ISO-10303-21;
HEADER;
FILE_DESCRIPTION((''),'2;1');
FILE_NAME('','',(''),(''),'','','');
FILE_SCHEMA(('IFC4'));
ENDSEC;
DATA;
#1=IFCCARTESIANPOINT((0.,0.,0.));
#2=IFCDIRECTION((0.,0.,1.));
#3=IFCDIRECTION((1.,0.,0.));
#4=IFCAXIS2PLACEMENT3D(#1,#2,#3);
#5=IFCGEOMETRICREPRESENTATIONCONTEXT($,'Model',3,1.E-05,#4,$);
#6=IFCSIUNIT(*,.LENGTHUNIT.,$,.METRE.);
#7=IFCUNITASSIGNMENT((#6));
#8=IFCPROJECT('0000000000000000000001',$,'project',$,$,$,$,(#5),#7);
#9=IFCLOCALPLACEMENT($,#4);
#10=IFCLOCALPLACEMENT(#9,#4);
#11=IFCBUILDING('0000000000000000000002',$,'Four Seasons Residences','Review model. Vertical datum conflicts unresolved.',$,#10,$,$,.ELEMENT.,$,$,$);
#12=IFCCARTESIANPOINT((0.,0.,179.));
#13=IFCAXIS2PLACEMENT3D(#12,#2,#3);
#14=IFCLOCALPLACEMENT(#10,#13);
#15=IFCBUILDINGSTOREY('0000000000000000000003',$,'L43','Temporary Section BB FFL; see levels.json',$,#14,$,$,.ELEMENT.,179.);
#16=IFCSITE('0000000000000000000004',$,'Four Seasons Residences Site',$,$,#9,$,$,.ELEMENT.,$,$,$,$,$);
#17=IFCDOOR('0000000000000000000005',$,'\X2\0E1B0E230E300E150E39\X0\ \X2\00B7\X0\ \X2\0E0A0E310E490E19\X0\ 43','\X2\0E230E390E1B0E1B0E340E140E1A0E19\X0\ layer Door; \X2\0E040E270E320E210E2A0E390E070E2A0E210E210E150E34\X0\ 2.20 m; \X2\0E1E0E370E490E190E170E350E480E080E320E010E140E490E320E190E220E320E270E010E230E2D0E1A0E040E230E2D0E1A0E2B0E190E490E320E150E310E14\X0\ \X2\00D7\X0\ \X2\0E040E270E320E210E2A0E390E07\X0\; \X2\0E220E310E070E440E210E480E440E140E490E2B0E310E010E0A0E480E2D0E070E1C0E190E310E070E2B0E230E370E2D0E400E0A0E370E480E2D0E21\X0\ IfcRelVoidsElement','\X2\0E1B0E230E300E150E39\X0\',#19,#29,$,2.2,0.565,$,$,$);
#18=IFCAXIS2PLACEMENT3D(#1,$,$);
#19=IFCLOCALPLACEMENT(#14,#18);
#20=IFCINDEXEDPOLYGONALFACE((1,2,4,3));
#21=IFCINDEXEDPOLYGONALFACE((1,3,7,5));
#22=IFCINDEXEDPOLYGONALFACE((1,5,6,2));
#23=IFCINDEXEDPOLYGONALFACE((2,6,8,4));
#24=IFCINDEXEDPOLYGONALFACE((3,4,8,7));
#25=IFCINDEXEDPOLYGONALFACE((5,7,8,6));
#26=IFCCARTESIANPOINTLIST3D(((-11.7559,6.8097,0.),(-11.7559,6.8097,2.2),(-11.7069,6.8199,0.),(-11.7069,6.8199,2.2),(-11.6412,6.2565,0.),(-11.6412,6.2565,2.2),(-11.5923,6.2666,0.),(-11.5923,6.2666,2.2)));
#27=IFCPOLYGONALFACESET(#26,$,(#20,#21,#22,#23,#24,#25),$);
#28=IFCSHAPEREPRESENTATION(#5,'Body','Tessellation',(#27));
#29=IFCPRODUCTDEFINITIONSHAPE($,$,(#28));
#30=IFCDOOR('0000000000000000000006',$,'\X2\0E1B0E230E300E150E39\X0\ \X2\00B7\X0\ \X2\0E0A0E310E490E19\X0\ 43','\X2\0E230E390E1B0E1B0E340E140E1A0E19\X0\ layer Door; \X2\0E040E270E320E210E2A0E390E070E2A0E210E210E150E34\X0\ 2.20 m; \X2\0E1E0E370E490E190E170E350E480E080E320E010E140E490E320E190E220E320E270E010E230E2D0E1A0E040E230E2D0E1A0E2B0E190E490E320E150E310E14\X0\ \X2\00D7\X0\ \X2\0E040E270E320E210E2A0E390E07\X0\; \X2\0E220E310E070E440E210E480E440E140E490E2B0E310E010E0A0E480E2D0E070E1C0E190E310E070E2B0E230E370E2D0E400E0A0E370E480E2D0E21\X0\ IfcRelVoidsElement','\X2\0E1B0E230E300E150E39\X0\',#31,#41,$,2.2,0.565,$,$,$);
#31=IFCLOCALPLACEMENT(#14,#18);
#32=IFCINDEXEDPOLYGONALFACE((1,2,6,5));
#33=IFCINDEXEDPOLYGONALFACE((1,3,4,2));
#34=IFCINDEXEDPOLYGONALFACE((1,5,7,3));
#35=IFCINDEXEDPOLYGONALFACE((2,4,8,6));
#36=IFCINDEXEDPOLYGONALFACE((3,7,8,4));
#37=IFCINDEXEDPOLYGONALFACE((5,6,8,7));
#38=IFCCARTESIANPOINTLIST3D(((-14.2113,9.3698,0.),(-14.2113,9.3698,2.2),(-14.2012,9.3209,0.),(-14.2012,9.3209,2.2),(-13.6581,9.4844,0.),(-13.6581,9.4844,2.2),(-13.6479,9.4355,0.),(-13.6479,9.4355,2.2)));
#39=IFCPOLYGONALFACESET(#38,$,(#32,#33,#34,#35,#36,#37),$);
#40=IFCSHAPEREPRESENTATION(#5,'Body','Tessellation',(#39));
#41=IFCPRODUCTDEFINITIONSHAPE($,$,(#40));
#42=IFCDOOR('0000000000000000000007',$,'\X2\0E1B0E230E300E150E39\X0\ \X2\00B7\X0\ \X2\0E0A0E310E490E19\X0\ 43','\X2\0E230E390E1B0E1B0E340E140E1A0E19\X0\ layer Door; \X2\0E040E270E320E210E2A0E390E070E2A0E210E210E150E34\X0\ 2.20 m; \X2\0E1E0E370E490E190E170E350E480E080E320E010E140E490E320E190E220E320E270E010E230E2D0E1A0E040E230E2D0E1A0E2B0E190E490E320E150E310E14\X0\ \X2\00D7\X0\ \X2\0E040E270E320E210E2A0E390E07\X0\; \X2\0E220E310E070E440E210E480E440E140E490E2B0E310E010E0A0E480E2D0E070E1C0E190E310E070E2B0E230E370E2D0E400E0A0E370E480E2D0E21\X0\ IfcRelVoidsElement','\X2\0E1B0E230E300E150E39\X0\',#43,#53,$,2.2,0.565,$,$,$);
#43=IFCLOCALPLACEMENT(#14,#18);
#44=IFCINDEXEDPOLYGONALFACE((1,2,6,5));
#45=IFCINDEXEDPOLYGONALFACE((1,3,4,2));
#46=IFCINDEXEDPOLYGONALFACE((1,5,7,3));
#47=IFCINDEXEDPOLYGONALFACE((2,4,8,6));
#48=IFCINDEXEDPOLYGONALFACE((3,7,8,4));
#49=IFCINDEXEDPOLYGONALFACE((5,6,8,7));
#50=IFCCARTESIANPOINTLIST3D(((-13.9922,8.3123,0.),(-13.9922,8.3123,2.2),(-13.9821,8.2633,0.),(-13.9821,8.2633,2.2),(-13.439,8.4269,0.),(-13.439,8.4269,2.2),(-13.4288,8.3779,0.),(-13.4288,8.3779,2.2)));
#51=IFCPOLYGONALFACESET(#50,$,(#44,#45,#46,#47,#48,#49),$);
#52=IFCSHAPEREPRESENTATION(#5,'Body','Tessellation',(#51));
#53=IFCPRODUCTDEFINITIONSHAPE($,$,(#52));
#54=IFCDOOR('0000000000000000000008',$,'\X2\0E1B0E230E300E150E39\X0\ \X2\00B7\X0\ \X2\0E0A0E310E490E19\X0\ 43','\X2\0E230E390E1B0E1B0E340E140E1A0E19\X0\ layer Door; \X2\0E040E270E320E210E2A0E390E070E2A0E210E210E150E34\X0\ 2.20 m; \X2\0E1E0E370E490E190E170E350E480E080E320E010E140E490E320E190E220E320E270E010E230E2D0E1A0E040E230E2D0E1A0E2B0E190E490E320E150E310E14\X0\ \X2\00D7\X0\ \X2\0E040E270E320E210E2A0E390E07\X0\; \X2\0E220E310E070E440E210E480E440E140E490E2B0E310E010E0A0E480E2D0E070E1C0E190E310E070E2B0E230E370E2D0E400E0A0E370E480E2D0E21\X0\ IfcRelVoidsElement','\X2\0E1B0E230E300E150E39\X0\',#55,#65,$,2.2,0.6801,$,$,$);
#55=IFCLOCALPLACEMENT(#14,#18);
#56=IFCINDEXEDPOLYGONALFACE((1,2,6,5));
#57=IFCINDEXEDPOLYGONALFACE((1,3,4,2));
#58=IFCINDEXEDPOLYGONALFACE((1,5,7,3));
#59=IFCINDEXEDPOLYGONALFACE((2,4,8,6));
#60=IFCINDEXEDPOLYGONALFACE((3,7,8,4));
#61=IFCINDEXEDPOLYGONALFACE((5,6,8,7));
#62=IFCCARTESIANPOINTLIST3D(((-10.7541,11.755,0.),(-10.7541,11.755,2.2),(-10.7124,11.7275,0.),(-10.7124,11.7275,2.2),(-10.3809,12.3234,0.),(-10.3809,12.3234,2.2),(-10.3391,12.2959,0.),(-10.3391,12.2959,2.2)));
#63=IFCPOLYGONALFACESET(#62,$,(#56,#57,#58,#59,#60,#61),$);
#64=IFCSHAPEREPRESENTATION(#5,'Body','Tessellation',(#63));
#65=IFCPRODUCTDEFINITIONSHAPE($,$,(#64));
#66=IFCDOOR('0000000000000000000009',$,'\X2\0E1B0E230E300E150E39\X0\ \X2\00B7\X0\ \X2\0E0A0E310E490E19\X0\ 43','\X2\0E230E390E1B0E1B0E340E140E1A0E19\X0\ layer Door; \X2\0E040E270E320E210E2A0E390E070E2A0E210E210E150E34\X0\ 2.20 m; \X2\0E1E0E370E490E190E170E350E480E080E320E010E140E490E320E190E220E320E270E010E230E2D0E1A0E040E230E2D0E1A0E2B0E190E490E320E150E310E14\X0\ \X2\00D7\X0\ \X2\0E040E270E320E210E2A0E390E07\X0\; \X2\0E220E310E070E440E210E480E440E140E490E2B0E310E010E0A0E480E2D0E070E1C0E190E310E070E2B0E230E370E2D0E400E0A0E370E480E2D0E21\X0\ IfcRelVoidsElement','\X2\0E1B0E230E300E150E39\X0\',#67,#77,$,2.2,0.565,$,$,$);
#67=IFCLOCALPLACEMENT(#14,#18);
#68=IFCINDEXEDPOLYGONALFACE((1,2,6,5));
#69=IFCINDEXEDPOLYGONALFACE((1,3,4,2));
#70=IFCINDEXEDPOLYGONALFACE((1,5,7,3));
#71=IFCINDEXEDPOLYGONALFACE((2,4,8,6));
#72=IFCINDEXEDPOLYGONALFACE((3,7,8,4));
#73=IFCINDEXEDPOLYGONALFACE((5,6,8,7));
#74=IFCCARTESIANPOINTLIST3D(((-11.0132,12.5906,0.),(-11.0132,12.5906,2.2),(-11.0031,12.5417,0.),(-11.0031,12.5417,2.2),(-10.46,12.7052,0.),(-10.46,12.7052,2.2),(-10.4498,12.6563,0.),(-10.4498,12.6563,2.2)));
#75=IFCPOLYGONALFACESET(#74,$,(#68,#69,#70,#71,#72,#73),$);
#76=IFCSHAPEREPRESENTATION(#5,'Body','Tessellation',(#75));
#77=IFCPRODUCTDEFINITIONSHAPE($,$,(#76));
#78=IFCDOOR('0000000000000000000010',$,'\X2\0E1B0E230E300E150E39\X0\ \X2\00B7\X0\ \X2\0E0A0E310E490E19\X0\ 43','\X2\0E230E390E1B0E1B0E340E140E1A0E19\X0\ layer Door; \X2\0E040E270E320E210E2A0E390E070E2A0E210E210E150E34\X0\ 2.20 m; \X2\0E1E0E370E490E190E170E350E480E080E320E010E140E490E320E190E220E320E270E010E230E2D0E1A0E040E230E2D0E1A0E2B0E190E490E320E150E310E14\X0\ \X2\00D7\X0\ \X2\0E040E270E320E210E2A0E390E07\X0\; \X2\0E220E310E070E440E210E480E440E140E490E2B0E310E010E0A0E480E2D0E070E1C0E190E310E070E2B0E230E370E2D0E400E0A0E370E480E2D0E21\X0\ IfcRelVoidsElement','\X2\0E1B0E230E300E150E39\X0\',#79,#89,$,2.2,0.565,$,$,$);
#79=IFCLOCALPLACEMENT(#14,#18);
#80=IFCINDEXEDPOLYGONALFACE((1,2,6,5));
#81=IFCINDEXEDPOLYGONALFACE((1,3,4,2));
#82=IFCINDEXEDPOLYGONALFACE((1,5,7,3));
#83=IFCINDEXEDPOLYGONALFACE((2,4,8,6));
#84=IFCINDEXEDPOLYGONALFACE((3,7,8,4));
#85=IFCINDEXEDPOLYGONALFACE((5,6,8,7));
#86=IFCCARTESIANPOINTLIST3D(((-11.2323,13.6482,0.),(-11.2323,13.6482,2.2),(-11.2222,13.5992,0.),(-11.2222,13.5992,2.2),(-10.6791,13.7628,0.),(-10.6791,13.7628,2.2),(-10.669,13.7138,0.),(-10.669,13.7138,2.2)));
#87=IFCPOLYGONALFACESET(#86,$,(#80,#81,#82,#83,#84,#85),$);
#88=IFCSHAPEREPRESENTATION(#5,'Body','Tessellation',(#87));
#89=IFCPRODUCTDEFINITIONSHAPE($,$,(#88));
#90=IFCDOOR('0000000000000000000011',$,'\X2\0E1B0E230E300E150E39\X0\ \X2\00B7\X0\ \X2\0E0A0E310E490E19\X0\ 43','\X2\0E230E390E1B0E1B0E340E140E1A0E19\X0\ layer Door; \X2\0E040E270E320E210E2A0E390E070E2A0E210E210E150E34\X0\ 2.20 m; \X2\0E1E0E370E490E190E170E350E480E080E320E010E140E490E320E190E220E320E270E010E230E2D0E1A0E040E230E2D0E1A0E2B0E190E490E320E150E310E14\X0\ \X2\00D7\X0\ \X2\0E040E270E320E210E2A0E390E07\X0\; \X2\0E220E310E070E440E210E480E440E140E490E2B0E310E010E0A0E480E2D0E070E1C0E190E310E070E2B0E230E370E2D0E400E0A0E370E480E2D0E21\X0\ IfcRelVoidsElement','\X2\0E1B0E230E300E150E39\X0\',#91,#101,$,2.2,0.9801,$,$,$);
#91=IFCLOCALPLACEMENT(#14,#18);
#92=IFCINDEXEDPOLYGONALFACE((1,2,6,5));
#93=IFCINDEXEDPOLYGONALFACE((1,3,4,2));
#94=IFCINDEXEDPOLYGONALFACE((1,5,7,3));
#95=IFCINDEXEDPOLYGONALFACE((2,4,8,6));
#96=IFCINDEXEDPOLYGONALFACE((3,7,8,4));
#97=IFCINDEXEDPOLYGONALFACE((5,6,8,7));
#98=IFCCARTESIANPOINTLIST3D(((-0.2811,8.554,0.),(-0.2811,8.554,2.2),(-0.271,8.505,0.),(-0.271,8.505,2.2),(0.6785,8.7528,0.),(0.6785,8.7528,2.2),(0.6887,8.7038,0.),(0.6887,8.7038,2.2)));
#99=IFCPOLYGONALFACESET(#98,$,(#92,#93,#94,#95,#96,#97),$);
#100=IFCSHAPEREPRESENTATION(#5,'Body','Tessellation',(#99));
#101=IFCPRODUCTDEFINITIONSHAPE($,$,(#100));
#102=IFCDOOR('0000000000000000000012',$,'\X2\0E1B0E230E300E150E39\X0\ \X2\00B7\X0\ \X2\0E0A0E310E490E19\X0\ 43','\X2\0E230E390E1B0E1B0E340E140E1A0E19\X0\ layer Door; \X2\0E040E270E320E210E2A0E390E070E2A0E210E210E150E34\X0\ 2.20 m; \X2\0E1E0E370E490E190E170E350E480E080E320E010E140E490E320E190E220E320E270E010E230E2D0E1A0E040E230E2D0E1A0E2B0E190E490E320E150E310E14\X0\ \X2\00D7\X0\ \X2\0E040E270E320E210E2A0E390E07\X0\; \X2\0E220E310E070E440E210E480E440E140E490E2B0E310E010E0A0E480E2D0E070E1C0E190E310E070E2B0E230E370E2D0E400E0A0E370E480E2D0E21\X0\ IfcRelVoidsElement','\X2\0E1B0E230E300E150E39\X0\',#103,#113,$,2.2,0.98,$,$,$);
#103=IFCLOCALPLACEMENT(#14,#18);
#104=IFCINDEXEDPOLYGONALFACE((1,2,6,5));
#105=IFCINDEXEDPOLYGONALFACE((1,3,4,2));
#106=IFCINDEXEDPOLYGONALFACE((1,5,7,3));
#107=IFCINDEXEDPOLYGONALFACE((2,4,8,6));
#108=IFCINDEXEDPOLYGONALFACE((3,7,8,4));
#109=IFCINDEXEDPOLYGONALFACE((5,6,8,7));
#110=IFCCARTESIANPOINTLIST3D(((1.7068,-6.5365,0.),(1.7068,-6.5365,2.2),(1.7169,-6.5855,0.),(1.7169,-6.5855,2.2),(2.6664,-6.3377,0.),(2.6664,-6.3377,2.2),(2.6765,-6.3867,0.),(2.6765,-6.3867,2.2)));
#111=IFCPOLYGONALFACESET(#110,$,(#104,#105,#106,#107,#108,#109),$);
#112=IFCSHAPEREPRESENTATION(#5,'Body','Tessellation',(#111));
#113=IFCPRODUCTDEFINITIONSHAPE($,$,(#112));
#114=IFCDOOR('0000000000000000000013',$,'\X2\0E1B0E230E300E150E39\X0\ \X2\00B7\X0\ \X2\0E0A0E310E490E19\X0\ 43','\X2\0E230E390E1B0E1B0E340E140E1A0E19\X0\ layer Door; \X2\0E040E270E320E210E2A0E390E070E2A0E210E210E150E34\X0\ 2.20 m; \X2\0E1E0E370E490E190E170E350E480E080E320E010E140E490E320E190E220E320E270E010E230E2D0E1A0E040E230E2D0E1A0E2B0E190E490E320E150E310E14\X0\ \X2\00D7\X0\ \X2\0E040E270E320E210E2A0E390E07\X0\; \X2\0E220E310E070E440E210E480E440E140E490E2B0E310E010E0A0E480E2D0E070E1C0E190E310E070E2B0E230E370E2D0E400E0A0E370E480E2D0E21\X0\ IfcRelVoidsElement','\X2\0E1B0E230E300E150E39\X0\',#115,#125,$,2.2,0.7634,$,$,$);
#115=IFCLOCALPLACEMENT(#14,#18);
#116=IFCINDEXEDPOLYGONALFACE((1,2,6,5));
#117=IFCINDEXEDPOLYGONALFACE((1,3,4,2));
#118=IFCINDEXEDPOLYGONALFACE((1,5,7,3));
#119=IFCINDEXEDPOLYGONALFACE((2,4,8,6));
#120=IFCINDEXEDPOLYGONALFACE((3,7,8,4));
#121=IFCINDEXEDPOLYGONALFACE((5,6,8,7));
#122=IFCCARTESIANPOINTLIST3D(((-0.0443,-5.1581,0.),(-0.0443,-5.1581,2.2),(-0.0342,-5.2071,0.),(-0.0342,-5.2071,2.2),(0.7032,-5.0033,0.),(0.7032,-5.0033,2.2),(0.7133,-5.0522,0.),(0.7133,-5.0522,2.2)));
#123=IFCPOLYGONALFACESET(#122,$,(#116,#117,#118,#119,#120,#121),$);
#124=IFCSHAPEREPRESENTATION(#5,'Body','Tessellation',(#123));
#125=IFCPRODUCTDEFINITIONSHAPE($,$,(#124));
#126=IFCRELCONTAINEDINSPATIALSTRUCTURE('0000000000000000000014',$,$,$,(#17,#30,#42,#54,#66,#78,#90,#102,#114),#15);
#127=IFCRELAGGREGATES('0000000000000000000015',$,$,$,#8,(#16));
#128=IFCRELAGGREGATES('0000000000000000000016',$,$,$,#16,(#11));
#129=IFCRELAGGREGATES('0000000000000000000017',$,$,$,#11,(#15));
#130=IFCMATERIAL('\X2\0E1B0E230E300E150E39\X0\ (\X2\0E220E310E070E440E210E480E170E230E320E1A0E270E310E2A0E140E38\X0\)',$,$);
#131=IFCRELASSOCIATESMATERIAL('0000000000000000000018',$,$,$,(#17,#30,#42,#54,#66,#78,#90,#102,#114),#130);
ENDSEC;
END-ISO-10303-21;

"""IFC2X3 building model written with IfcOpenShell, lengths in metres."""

from ifc_helpers import new_model, si_unit, frame, origin_with_axes, place, context, project, spatial, polyline, outline, extrude, material, element, save


model = new_model("IFC2X3")

# Units and contexts
model_context = context("Model", 3, precision=1e-05, world=origin_with_axes())
ifc_project = project(units=[si_unit("LENGTHUNIT", "METRE")], contexts=[model_context])

# Site, building, storey
site_placement = place(None, origin_with_axes())
site = spatial("IfcSite", under=ifc_project, at=site_placement, Name="Four Seasons Residences Site", CompositionType="ELEMENT")
building_placement = place(site_placement, origin_with_axes())
building = spatial("IfcBuilding", under=site, at=building_placement, Name="Four Seasons Residences", Description="Review model. Vertical datum conflicts unresolved.", CompositionType="ELEMENT")
storey_placement = place(building_placement, frame((0.0, 0.0, 179.0), z_axis=(0.0, 0.0, 1.0), x_axis=(1.0, 0.0, 0.0)))
storey = spatial("IfcBuildingStorey", under=building, at=storey_placement, Name="L43", Description="Temporary Section BB FFL; see levels.json", CompositionType="ELEMENT", Elevation=179.0)

# Doors
ifc_material_1 = material(Name="ประตู (ยังไม่ทราบวัสดุ)")
door_1_placement = place(storey_placement, origin_with_axes())
element("IfcDoor", 1, at=door_1_placement, inside=storey, material=ifc_material_1, Name="ประตู · ชั้น 43", Description="รูปปิดบน layer Door; ความสูงสมมติ 2.20 m; พื้นที่จากด้านยาวกรอบครอบหน้าตัด × ความสูง; ยังไม่ได้หักช่องผนังหรือเชื่อม IfcRelVoidsElement", ObjectType="ประตู", OverallHeight=2.2, OverallWidth=0.565, context=model_context, shape_type="SweptSolid", body=[
    extrude(outline(polyline([(-11.5923, 6.2666), (-11.7069, 6.8199), (-11.7559, 6.8097), (-11.6412, 6.2565), (-11.5923, 6.2666)])), origin_with_axes(), (0.0, 0.0, 1.0), 2.2),
])
door_2_placement = place(storey_placement, origin_with_axes())
element("IfcDoor", 2, at=door_2_placement, inside=storey, material=ifc_material_1, Name="ประตู · ชั้น 43", Description="รูปปิดบน layer Door; ความสูงสมมติ 2.20 m; พื้นที่จากด้านยาวกรอบครอบหน้าตัด × ความสูง; ยังไม่ได้หักช่องผนังหรือเชื่อม IfcRelVoidsElement", ObjectType="ประตู", OverallHeight=2.2, OverallWidth=0.565, context=model_context, shape_type="SweptSolid", body=[
    extrude(outline(polyline([(-13.6581, 9.4844), (-14.2113, 9.3698), (-14.2012, 9.3209), (-13.6479, 9.4355), (-13.6581, 9.4844)])), origin_with_axes(), (0.0, 0.0, 1.0), 2.2),
])
door_3_placement = place(storey_placement, origin_with_axes())
element("IfcDoor", 3, at=door_3_placement, inside=storey, material=ifc_material_1, Name="ประตู · ชั้น 43", Description="รูปปิดบน layer Door; ความสูงสมมติ 2.20 m; พื้นที่จากด้านยาวกรอบครอบหน้าตัด × ความสูง; ยังไม่ได้หักช่องผนังหรือเชื่อม IfcRelVoidsElement", ObjectType="ประตู", OverallHeight=2.2, OverallWidth=0.565, context=model_context, shape_type="SweptSolid", body=[
    extrude(outline(polyline([(-13.4288, 8.3779), (-13.9821, 8.2633), (-13.9922, 8.3123), (-13.439, 8.4269), (-13.4288, 8.3779)])), origin_with_axes(), (0.0, 0.0, 1.0), 2.2),
])
door_4_placement = place(storey_placement, origin_with_axes())
element("IfcDoor", 4, at=door_4_placement, inside=storey, material=ifc_material_1, Name="ประตู · ชั้น 43", Description="รูปปิดบน layer Door; ความสูงสมมติ 2.20 m; พื้นที่จากด้านยาวกรอบครอบหน้าตัด × ความสูง; ยังไม่ได้หักช่องผนังหรือเชื่อม IfcRelVoidsElement", ObjectType="ประตู", OverallHeight=2.2, OverallWidth=0.6801, context=model_context, shape_type="SweptSolid", body=[
    extrude(outline(polyline([(-10.7541, 11.755), (-10.3809, 12.3234), (-10.3391, 12.2959), (-10.7124, 11.7275), (-10.7541, 11.755)])), origin_with_axes(), (0.0, 0.0, 1.0), 2.2),
])
door_5_placement = place(storey_placement, origin_with_axes())
element("IfcDoor", 5, at=door_5_placement, inside=storey, material=ifc_material_1, Name="ประตู · ชั้น 43", Description="รูปปิดบน layer Door; ความสูงสมมติ 2.20 m; พื้นที่จากด้านยาวกรอบครอบหน้าตัด × ความสูง; ยังไม่ได้หักช่องผนังหรือเชื่อม IfcRelVoidsElement", ObjectType="ประตู", OverallHeight=2.2, OverallWidth=0.565, context=model_context, shape_type="SweptSolid", body=[
    extrude(outline(polyline([(-11.0031, 12.5417), (-10.4498, 12.6563), (-10.46, 12.7052), (-11.0132, 12.5906), (-11.0031, 12.5417)])), origin_with_axes(), (0.0, 0.0, 1.0), 2.2),
])
door_6_placement = place(storey_placement, origin_with_axes())
element("IfcDoor", 6, at=door_6_placement, inside=storey, material=ifc_material_1, Name="ประตู · ชั้น 43", Description="รูปปิดบน layer Door; ความสูงสมมติ 2.20 m; พื้นที่จากด้านยาวกรอบครอบหน้าตัด × ความสูง; ยังไม่ได้หักช่องผนังหรือเชื่อม IfcRelVoidsElement", ObjectType="ประตู", OverallHeight=2.2, OverallWidth=0.565, context=model_context, shape_type="SweptSolid", body=[
    extrude(outline(polyline([(-11.2323, 13.6482), (-10.6791, 13.7628), (-10.669, 13.7138), (-11.2222, 13.5992), (-11.2323, 13.6482)])), origin_with_axes(), (0.0, 0.0, 1.0), 2.2),
])
door_7_placement = place(storey_placement, origin_with_axes())
element("IfcDoor", 7, at=door_7_placement, inside=storey, material=ifc_material_1, Name="ประตู · ชั้น 43", Description="รูปปิดบน layer Door; ความสูงสมมติ 2.20 m; พื้นที่จากด้านยาวกรอบครอบหน้าตัด × ความสูง; ยังไม่ได้หักช่องผนังหรือเชื่อม IfcRelVoidsElement", ObjectType="ประตู", OverallHeight=2.2, OverallWidth=0.9801, context=model_context, shape_type="SweptSolid", body=[
    extrude(outline(polyline([(-0.2811, 8.554), (-0.271, 8.505), (0.6887, 8.7038), (0.6785, 8.7528), (-0.2811, 8.554)])), origin_with_axes(), (0.0, 0.0, 1.0), 2.2),
])
door_8_placement = place(storey_placement, origin_with_axes())
element("IfcDoor", 8, at=door_8_placement, inside=storey, material=ifc_material_1, Name="ประตู · ชั้น 43", Description="รูปปิดบน layer Door; ความสูงสมมติ 2.20 m; พื้นที่จากด้านยาวกรอบครอบหน้าตัด × ความสูง; ยังไม่ได้หักช่องผนังหรือเชื่อม IfcRelVoidsElement", ObjectType="ประตู", OverallHeight=2.2, OverallWidth=0.98, context=model_context, shape_type="SweptSolid", body=[
    extrude(outline(polyline([(2.6765, -6.3867), (2.6664, -6.3377), (1.7068, -6.5365), (1.7169, -6.5855), (2.6765, -6.3867)])), origin_with_axes(), (0.0, 0.0, 1.0), 2.2),
])
door_9_placement = place(storey_placement, origin_with_axes())
element("IfcDoor", 9, at=door_9_placement, inside=storey, material=ifc_material_1, Name="ประตู · ชั้น 43", Description="รูปปิดบน layer Door; ความสูงสมมติ 2.20 m; พื้นที่จากด้านยาวกรอบครอบหน้าตัด × ความสูง; ยังไม่ได้หักช่องผนังหรือเชื่อม IfcRelVoidsElement", ObjectType="ประตู", OverallHeight=2.2, OverallWidth=0.7634, context=model_context, shape_type="SweptSolid", body=[
    extrude(outline(polyline([(0.7032, -5.0033), (-0.0443, -5.1581), (-0.0342, -5.2071), (0.7133, -5.0522), (0.7032, -5.0033)])), origin_with_axes(), (0.0, 0.0, 1.0), 2.2),
])

save(model, "model.ifc")
